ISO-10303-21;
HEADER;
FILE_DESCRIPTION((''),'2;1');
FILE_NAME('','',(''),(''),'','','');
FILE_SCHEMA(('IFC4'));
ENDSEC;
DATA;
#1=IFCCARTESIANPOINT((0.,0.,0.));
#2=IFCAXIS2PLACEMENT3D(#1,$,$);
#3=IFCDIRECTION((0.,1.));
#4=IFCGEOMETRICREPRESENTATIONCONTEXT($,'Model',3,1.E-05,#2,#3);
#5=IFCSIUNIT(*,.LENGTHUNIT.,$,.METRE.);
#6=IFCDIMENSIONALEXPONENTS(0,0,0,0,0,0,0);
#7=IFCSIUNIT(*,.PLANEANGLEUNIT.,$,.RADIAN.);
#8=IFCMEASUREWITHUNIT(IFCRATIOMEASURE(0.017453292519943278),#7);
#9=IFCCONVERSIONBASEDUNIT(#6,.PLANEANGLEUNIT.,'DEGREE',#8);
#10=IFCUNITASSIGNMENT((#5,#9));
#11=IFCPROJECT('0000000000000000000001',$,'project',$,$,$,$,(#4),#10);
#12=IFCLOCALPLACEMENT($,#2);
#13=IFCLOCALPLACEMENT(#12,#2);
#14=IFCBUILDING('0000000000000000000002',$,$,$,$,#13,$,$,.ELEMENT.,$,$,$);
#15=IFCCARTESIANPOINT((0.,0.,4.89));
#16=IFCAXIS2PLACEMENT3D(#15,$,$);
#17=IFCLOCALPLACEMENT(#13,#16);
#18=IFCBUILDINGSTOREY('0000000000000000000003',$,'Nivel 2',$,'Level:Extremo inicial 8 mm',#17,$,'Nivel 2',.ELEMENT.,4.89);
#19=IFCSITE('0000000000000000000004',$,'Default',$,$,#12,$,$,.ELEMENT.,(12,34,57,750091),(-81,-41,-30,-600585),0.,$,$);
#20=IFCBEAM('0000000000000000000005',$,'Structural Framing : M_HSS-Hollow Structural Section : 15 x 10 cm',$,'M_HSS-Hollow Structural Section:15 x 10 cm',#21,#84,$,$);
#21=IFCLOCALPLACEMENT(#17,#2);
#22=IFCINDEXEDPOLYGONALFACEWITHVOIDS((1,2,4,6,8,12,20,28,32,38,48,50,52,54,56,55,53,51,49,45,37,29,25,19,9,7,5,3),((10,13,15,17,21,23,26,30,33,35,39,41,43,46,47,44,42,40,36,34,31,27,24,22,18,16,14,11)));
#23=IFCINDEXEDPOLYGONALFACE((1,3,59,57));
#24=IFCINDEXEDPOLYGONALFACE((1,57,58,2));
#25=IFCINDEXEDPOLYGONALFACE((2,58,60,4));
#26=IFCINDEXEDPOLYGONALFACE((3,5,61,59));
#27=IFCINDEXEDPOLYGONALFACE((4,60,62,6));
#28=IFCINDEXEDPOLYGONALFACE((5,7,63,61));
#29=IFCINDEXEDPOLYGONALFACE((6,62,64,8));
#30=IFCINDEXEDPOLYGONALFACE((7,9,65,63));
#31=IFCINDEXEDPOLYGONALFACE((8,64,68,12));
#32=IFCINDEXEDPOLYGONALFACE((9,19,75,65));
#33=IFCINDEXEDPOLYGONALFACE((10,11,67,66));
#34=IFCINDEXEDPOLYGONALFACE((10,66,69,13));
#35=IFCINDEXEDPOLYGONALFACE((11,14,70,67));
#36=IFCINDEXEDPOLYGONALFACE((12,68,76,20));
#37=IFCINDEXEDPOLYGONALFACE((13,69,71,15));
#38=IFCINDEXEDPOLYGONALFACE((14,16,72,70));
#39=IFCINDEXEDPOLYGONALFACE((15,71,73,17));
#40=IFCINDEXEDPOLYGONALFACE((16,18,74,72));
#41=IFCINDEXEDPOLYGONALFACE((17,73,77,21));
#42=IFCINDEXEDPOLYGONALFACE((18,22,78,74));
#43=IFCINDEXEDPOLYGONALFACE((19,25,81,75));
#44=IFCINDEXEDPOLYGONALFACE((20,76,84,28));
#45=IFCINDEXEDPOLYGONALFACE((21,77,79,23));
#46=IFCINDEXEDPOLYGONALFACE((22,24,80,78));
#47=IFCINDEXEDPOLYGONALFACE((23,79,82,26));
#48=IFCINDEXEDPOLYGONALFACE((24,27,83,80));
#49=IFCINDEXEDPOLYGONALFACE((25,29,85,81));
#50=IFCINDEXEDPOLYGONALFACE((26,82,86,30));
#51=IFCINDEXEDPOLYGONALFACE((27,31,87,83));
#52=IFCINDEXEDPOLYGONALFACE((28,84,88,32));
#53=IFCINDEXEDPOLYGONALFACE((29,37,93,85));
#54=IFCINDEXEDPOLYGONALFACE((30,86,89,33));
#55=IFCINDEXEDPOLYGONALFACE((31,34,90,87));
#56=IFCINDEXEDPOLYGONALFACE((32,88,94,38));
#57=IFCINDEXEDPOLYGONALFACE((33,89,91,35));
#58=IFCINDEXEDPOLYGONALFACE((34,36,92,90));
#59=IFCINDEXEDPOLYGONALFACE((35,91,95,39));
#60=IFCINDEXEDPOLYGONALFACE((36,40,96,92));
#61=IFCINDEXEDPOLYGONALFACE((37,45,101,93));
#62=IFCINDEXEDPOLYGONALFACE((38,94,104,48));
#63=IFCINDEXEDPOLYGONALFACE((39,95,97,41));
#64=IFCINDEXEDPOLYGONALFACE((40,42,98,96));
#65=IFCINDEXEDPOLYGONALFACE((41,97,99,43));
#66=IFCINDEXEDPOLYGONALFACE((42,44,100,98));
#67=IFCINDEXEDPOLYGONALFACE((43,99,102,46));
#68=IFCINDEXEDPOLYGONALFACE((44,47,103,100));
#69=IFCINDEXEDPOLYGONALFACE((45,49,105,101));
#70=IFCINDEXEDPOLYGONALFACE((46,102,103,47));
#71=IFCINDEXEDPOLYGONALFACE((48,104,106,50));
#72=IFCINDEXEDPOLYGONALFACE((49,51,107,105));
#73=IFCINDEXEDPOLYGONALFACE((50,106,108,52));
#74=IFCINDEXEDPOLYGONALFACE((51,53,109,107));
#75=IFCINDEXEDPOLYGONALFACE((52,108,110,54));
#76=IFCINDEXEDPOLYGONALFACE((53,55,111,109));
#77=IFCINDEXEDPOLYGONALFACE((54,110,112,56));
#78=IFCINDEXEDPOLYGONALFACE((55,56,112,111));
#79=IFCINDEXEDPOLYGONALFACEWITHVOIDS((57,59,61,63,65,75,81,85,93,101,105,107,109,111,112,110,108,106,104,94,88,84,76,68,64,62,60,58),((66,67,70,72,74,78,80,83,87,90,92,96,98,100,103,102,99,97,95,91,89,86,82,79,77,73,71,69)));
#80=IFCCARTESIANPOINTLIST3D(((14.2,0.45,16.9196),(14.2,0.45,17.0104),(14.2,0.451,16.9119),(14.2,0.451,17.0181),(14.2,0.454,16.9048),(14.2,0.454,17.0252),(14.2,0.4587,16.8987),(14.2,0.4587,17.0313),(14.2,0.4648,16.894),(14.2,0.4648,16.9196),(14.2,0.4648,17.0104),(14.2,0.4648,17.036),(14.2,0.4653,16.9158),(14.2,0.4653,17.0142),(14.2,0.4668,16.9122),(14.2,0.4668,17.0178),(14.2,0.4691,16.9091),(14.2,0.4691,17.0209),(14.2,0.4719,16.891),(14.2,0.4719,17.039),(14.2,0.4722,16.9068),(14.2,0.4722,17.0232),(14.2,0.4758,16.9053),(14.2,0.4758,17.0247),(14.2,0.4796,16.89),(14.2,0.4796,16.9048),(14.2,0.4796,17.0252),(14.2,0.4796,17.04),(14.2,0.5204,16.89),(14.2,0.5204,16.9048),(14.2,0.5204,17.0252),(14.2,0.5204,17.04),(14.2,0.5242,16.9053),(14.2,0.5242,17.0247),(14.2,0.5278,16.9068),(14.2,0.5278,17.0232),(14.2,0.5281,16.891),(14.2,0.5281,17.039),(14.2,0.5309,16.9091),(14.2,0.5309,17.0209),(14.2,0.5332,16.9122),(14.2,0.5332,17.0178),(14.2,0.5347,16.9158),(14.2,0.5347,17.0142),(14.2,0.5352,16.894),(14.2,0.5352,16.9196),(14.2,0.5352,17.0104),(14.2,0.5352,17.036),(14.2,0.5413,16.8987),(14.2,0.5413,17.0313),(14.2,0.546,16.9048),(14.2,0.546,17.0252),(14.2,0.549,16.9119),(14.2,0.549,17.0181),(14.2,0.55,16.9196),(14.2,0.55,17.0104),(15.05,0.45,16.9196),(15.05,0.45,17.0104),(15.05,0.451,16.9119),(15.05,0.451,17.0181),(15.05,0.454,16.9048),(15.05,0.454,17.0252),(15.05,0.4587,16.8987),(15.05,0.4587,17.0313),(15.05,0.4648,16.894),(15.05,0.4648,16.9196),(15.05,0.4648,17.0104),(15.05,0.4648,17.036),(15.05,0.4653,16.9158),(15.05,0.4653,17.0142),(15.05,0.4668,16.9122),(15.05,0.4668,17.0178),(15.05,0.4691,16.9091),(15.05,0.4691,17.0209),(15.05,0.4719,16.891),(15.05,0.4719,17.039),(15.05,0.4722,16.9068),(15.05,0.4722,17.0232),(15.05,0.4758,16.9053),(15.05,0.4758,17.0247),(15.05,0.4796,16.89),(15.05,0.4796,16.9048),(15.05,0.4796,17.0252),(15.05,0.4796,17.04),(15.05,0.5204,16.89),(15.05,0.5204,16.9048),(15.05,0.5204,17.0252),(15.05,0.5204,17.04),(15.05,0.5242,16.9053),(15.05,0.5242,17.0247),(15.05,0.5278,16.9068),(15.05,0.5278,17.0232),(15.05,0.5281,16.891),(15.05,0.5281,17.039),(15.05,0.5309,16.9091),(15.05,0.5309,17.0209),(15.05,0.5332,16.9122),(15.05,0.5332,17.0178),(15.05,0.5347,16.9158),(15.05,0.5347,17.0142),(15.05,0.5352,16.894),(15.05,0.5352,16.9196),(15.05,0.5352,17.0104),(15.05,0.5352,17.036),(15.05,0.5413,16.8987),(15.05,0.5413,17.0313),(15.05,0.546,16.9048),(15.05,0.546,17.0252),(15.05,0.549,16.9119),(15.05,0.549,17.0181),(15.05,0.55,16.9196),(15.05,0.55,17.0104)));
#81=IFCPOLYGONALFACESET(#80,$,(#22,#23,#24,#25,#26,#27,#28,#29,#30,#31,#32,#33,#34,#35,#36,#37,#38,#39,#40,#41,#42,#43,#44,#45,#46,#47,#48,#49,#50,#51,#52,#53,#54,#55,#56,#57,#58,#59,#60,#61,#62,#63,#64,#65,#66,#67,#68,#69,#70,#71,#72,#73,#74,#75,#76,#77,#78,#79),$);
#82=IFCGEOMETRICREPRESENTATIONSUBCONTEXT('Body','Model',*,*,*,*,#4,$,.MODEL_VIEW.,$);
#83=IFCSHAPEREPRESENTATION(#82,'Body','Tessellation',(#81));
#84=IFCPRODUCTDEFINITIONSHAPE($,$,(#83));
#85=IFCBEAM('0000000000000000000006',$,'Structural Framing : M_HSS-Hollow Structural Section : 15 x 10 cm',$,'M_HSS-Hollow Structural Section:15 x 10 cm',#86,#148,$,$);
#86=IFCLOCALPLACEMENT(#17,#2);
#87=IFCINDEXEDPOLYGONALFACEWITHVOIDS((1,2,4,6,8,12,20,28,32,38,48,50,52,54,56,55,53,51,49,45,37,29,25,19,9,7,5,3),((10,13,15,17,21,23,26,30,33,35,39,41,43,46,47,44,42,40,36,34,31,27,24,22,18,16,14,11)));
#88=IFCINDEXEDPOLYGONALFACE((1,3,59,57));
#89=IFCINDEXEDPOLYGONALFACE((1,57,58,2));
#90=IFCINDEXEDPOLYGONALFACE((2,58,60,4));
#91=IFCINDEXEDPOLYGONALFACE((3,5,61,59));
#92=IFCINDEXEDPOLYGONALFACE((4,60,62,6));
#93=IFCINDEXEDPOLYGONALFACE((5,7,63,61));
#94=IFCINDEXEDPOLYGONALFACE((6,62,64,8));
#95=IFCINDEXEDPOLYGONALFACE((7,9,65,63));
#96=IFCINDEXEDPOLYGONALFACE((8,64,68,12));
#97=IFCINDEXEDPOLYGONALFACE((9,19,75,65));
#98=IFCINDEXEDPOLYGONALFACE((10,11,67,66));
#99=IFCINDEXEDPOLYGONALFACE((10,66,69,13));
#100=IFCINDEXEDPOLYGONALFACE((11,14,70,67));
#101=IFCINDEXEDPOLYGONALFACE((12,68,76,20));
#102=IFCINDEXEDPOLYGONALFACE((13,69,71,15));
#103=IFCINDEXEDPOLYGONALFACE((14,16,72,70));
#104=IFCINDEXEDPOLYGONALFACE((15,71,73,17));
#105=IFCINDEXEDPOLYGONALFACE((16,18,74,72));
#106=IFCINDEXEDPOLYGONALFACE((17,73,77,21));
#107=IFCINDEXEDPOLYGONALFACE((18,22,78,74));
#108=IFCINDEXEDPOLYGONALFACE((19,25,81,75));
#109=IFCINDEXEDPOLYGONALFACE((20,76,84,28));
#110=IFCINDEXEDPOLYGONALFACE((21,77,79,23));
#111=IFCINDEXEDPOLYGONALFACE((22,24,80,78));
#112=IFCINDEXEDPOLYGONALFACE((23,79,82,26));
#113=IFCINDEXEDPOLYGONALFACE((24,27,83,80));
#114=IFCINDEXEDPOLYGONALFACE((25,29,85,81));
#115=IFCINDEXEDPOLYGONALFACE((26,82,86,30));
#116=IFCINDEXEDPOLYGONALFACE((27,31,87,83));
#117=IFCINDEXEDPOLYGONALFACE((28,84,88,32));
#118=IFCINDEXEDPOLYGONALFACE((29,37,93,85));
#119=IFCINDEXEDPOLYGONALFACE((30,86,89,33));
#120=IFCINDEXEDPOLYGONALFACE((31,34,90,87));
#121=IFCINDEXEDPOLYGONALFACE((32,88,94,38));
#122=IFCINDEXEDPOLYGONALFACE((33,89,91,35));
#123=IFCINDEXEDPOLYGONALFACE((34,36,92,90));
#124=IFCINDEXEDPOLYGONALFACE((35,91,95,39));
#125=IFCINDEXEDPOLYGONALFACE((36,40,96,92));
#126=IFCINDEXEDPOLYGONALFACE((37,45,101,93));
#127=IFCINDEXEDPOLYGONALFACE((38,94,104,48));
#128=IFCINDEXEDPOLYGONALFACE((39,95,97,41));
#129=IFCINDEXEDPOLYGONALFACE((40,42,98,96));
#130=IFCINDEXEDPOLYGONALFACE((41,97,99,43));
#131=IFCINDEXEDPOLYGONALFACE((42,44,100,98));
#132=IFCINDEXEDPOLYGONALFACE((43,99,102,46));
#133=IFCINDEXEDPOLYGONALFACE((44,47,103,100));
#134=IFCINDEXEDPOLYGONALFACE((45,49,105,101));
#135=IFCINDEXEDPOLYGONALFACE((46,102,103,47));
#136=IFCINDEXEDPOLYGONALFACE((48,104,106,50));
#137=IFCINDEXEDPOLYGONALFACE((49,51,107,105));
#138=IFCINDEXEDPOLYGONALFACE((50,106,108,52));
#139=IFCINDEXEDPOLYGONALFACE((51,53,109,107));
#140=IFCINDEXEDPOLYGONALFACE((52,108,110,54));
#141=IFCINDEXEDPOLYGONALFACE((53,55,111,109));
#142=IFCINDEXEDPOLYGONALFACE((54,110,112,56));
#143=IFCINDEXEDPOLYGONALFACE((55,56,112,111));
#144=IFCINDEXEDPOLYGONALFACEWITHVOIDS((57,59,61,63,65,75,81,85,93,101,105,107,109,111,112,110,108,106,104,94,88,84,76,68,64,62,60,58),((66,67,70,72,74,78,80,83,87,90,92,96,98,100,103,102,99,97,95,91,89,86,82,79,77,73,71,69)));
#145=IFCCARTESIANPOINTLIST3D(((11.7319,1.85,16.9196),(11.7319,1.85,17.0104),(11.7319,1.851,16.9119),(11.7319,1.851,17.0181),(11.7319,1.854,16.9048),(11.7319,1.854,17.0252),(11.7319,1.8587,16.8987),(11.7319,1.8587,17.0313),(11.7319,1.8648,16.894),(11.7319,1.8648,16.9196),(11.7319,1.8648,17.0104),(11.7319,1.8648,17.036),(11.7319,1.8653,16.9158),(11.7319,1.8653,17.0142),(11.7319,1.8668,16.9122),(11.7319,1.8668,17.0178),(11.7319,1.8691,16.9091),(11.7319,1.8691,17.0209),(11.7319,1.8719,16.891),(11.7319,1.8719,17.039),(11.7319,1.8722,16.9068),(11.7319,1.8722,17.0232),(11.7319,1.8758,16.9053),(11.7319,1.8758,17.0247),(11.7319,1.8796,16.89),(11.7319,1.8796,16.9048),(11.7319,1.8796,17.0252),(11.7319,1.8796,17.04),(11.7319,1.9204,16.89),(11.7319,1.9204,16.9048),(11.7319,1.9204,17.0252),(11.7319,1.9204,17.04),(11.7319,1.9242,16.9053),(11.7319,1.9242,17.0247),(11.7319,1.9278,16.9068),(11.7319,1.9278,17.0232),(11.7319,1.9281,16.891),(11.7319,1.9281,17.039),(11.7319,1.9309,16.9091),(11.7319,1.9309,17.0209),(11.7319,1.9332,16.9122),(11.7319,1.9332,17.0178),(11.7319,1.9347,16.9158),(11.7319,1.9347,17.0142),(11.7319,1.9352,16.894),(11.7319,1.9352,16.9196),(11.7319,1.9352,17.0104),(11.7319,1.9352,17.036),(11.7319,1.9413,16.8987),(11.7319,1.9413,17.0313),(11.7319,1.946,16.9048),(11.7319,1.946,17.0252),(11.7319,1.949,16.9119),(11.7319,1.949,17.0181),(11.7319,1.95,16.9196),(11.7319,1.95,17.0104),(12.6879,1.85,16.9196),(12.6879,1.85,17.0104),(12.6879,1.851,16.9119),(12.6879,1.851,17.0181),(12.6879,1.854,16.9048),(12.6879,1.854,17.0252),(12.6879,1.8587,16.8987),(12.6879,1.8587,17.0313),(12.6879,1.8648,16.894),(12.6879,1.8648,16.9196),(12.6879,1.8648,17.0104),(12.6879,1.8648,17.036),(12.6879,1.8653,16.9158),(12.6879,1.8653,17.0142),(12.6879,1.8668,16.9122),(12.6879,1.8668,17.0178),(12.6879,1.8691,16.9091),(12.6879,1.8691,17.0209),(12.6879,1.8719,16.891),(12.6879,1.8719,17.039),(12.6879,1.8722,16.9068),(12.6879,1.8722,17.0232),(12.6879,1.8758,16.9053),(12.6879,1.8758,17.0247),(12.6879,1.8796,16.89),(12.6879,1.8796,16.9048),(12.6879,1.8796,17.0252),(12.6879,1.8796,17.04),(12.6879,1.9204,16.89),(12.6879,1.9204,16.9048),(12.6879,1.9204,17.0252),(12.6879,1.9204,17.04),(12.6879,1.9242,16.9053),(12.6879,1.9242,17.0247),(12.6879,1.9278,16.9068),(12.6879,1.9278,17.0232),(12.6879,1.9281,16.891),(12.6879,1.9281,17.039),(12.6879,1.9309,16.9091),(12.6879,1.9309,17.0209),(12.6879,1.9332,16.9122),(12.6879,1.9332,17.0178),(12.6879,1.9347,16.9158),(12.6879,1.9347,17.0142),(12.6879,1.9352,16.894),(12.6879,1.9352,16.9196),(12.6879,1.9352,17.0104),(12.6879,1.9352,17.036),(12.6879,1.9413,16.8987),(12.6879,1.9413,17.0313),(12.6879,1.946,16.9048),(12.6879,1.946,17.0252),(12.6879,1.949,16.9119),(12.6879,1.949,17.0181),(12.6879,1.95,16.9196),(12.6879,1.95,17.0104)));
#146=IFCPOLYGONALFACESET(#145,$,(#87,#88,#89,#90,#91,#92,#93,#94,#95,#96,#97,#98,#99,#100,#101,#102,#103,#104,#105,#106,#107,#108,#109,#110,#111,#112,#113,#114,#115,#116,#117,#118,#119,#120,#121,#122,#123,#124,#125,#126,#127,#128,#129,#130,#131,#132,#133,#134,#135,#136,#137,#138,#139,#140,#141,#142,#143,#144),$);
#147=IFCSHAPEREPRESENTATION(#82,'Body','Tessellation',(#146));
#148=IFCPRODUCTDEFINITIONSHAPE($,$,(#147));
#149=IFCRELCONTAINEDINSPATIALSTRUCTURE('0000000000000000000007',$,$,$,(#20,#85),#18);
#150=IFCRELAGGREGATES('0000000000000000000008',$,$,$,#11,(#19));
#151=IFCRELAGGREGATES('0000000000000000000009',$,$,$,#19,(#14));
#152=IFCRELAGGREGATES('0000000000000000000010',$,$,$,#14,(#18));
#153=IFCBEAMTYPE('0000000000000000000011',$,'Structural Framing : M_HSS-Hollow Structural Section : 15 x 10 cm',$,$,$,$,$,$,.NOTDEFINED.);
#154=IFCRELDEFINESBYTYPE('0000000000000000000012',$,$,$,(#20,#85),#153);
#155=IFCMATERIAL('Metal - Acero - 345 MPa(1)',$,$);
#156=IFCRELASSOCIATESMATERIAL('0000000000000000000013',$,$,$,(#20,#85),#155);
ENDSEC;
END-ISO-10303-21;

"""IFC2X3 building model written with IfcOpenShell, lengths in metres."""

from ifc_helpers import new_model, entity, si_unit, converted_unit, direction, frame, frame_2d, origin, place, context, subcontext, project, spatial, polyline, circle_curve, parameter, trimmed, segment, composite_curve, outline, extrude, material, type_object, element, save


model = new_model("IFC2X3")

# Units and contexts
model_context = context("Model", 3, precision=1e-05, world=origin(), true_north=direction((0.0, 1.0)))
body_context = subcontext(model_context, "Body", "Model", "MODEL_VIEW")
ifc_project = project(units=[si_unit("LENGTHUNIT", "METRE"), converted_unit("PLANEANGLEUNIT", "DEGREE", entity("IfcRatioMeasure", 0.017453292519943278), si_unit("PLANEANGLEUNIT", "RADIAN"), dimensions=[0, 0, 0, 0, 0, 0, 0])], contexts=[model_context])

# Site, building, storey
site_placement = place(None, origin())
site = spatial("IfcSite", under=ifc_project, at=site_placement, Name="Default", CompositionType="ELEMENT", RefLatitude=(12, 34, 57, 750091), RefLongitude=(-81, -41, -30, -600585), RefElevation=0.0)
building_placement = place(site_placement, origin())
building = spatial("IfcBuilding", under=site, at=building_placement, CompositionType="ELEMENT")
storey_placement = place(building_placement, frame((0.0, 0.0, 4.89)))
storey = spatial("IfcBuildingStorey", under=building, at=storey_placement, Name="Nivel 2", ObjectType="Level:Extremo inicial 8 mm", LongName="Nivel 2", CompositionType="ELEMENT", Elevation=4.89)

# Beams
ifc_material_1 = material(Name="Metal - Acero - 345 MPa(1)")
beam_type_1 = type_object("IfcBeamType", Name="Structural Framing : M_HSS-Hollow Structural Section : 15 x 10 cm", PredefinedType="NOTDEFINED")
beam_1_placement = place(storey_placement, frame((13.85, 0.5, 17.04)))
element("IfcBeam", 1, at=beam_1_placement, inside=storey, type_object=beam_type_1, material=ifc_material_1, Name="Structural Framing : M_HSS-Hollow Structural Section : 15 x 10 cm", ObjectType="M_HSS-Hollow Structural Section:15 x 10 cm", context=body_context, shape_type="SweptSolid", body=[
    extrude(outline(composite_curve([segment(trimmed(circle_curve(frame_2d((-0.0204, -0.0454), x_axis=(1.0, 0.0)), 0.0296), [parameter(180.0)], [parameter(270.0)], True, "PARAMETER"), True, "CONTINUOUS"), segment(polyline([(-0.0204, -0.075), (0.0204, -0.075)]), True, "CONTINUOUS"), segment(trimmed(circle_curve(frame_2d((0.0204, -0.0454), x_axis=(1.0, 0.0)), 0.0296), [parameter(270.0)], [parameter(0.0)], True, "PARAMETER"), True, "CONTINUOUS"), segment(polyline([(0.05, -0.0454), (0.05, 0.0454)]), True, "CONTINUOUS"), segment(trimmed(circle_curve(frame_2d((0.0204, 0.0454), x_axis=(1.0, 0.0)), 0.0296), [parameter(360.0)], [parameter(90.0)], True, "PARAMETER"), True, "CONTINUOUS"), segment(polyline([(0.0204, 0.075), (-0.0204, 0.075)]), True, "CONTINUOUS"), segment(trimmed(circle_curve(frame_2d((-0.0204, 0.0454), x_axis=(1.0, 0.0)), 0.0296), [parameter(90.0)], [parameter(180.0)], True, "PARAMETER"), True, "CONTINUOUS"), segment(polyline([(-0.05, 0.0454), (-0.05, -0.0454)]), True, "CONTINUOUS")], self_intersect=False), holes=[composite_curve([segment(polyline([(0.0204, -0.0602), (-0.0204, -0.0602)]), True, "CONTINUOUS"), segment(trimmed(circle_curve(frame_2d((-0.0204, -0.0454), x_axis=(1.0, 0.0)), 0.0148), [parameter(180.0)], [parameter(270.0)], True, "PARAMETER"), False, "CONTINUOUS"), segment(polyline([(-0.0352, -0.0454), (-0.0352, 0.0454)]), True, "CONTINUOUS"), segment(trimmed(circle_curve(frame_2d((-0.0204, 0.0454), x_axis=(1.0, 0.0)), 0.0148), [parameter(90.0)], [parameter(180.0)], True, "PARAMETER"), False, "CONTINUOUS"), segment(polyline([(-0.0204, 0.0602), (0.0204, 0.0602)]), True, "CONTINUOUS"), segment(trimmed(circle_curve(frame_2d((0.0204, 0.0454), x_axis=(1.0, 0.0)), 0.0148), [parameter(0.0)], [parameter(90.0)], True, "PARAMETER"), False, "CONTINUOUS"), segment(polyline([(0.0352, 0.0454), (0.0352, -0.0454)]), True, "CONTINUOUS"), segment(trimmed(circle_curve(frame_2d((0.0204, -0.0454), x_axis=(1.0, 0.0)), 0.0148), [parameter(270.0)], [parameter(0.0)], True, "PARAMETER"), False, "CONTINUOUS")], self_intersect=False)]), frame((0.35, 0.0, -0.075), z_axis=(1.0, 0.0, 0.0), x_axis=(0.0, -1.0, 0.0)), (0.0, 0.0, 1.0), 0.85),
])
beam_2_placement = place(storey_placement, frame((12.6879, 1.9, 17.04), z_axis=(0.0, 0.0, 1.0), x_axis=(-1.0, 0.0, 0.0)))
element("IfcBeam", 2, at=beam_2_placement, inside=storey, type_object=beam_type_1, material=ifc_material_1, Name="Structural Framing : M_HSS-Hollow Structural Section : 15 x 10 cm", ObjectType="M_HSS-Hollow Structural Section:15 x 10 cm", context=body_context, shape_type="SweptSolid", body=[
    extrude(outline(composite_curve([segment(trimmed(circle_curve(frame_2d((-0.0204, -0.0454), x_axis=(1.0, 0.0)), 0.0296), [parameter(180.0)], [parameter(270.0)], True, "PARAMETER"), True, "CONTINUOUS"), segment(polyline([(-0.0204, -0.075), (0.0204, -0.075)]), True, "CONTINUOUS"), segment(trimmed(circle_curve(frame_2d((0.0204, -0.0454), x_axis=(1.0, 0.0)), 0.0296), [parameter(270.0)], [parameter(0.0)], True, "PARAMETER"), True, "CONTINUOUS"), segment(polyline([(0.05, -0.0454), (0.05, 0.0454)]), True, "CONTINUOUS"), segment(trimmed(circle_curve(frame_2d((0.0204, 0.0454), x_axis=(1.0, 0.0)), 0.0296), [parameter(360.0)], [parameter(90.0)], True, "PARAMETER"), True, "CONTINUOUS"), segment(polyline([(0.0204, 0.075), (-0.0204, 0.075)]), True, "CONTINUOUS"), segment(trimmed(circle_curve(frame_2d((-0.0204, 0.0454), x_axis=(1.0, 0.0)), 0.0296), [parameter(90.0)], [parameter(180.0)], True, "PARAMETER"), True, "CONTINUOUS"), segment(polyline([(-0.05, 0.0454), (-0.05, -0.0454)]), True, "CONTINUOUS")], self_intersect=False), holes=[composite_curve([segment(polyline([(0.0204, -0.0602), (-0.0204, -0.0602)]), True, "CONTINUOUS"), segment(trimmed(circle_curve(frame_2d((-0.0204, -0.0454), x_axis=(1.0, 0.0)), 0.0148), [parameter(180.0)], [parameter(270.0)], True, "PARAMETER"), False, "CONTINUOUS"), segment(polyline([(-0.0352, -0.0454), (-0.0352, 0.0454)]), True, "CONTINUOUS"), segment(trimmed(circle_curve(frame_2d((-0.0204, 0.0454), x_axis=(1.0, 0.0)), 0.0148), [parameter(90.0)], [parameter(180.0)], True, "PARAMETER"), False, "CONTINUOUS"), segment(polyline([(-0.0204, 0.0602), (0.0204, 0.0602)]), True, "CONTINUOUS"), segment(trimmed(circle_curve(frame_2d((0.0204, 0.0454), x_axis=(1.0, 0.0)), 0.0148), [parameter(0.0)], [parameter(90.0)], True, "PARAMETER"), False, "CONTINUOUS"), segment(polyline([(0.0352, 0.0454), (0.0352, -0.0454)]), True, "CONTINUOUS"), segment(trimmed(circle_curve(frame_2d((0.0204, -0.0454), x_axis=(1.0, 0.0)), 0.0148), [parameter(270.0)], [parameter(0.0)], True, "PARAMETER"), False, "CONTINUOUS")], self_intersect=False)]), frame((0.0, 0.0, -0.075), z_axis=(1.0, 0.0, 0.0), x_axis=(0.0, -1.0, 0.0)), (0.0, 0.0, 1.0), 0.956),
])

save(model, "model.ifc")
